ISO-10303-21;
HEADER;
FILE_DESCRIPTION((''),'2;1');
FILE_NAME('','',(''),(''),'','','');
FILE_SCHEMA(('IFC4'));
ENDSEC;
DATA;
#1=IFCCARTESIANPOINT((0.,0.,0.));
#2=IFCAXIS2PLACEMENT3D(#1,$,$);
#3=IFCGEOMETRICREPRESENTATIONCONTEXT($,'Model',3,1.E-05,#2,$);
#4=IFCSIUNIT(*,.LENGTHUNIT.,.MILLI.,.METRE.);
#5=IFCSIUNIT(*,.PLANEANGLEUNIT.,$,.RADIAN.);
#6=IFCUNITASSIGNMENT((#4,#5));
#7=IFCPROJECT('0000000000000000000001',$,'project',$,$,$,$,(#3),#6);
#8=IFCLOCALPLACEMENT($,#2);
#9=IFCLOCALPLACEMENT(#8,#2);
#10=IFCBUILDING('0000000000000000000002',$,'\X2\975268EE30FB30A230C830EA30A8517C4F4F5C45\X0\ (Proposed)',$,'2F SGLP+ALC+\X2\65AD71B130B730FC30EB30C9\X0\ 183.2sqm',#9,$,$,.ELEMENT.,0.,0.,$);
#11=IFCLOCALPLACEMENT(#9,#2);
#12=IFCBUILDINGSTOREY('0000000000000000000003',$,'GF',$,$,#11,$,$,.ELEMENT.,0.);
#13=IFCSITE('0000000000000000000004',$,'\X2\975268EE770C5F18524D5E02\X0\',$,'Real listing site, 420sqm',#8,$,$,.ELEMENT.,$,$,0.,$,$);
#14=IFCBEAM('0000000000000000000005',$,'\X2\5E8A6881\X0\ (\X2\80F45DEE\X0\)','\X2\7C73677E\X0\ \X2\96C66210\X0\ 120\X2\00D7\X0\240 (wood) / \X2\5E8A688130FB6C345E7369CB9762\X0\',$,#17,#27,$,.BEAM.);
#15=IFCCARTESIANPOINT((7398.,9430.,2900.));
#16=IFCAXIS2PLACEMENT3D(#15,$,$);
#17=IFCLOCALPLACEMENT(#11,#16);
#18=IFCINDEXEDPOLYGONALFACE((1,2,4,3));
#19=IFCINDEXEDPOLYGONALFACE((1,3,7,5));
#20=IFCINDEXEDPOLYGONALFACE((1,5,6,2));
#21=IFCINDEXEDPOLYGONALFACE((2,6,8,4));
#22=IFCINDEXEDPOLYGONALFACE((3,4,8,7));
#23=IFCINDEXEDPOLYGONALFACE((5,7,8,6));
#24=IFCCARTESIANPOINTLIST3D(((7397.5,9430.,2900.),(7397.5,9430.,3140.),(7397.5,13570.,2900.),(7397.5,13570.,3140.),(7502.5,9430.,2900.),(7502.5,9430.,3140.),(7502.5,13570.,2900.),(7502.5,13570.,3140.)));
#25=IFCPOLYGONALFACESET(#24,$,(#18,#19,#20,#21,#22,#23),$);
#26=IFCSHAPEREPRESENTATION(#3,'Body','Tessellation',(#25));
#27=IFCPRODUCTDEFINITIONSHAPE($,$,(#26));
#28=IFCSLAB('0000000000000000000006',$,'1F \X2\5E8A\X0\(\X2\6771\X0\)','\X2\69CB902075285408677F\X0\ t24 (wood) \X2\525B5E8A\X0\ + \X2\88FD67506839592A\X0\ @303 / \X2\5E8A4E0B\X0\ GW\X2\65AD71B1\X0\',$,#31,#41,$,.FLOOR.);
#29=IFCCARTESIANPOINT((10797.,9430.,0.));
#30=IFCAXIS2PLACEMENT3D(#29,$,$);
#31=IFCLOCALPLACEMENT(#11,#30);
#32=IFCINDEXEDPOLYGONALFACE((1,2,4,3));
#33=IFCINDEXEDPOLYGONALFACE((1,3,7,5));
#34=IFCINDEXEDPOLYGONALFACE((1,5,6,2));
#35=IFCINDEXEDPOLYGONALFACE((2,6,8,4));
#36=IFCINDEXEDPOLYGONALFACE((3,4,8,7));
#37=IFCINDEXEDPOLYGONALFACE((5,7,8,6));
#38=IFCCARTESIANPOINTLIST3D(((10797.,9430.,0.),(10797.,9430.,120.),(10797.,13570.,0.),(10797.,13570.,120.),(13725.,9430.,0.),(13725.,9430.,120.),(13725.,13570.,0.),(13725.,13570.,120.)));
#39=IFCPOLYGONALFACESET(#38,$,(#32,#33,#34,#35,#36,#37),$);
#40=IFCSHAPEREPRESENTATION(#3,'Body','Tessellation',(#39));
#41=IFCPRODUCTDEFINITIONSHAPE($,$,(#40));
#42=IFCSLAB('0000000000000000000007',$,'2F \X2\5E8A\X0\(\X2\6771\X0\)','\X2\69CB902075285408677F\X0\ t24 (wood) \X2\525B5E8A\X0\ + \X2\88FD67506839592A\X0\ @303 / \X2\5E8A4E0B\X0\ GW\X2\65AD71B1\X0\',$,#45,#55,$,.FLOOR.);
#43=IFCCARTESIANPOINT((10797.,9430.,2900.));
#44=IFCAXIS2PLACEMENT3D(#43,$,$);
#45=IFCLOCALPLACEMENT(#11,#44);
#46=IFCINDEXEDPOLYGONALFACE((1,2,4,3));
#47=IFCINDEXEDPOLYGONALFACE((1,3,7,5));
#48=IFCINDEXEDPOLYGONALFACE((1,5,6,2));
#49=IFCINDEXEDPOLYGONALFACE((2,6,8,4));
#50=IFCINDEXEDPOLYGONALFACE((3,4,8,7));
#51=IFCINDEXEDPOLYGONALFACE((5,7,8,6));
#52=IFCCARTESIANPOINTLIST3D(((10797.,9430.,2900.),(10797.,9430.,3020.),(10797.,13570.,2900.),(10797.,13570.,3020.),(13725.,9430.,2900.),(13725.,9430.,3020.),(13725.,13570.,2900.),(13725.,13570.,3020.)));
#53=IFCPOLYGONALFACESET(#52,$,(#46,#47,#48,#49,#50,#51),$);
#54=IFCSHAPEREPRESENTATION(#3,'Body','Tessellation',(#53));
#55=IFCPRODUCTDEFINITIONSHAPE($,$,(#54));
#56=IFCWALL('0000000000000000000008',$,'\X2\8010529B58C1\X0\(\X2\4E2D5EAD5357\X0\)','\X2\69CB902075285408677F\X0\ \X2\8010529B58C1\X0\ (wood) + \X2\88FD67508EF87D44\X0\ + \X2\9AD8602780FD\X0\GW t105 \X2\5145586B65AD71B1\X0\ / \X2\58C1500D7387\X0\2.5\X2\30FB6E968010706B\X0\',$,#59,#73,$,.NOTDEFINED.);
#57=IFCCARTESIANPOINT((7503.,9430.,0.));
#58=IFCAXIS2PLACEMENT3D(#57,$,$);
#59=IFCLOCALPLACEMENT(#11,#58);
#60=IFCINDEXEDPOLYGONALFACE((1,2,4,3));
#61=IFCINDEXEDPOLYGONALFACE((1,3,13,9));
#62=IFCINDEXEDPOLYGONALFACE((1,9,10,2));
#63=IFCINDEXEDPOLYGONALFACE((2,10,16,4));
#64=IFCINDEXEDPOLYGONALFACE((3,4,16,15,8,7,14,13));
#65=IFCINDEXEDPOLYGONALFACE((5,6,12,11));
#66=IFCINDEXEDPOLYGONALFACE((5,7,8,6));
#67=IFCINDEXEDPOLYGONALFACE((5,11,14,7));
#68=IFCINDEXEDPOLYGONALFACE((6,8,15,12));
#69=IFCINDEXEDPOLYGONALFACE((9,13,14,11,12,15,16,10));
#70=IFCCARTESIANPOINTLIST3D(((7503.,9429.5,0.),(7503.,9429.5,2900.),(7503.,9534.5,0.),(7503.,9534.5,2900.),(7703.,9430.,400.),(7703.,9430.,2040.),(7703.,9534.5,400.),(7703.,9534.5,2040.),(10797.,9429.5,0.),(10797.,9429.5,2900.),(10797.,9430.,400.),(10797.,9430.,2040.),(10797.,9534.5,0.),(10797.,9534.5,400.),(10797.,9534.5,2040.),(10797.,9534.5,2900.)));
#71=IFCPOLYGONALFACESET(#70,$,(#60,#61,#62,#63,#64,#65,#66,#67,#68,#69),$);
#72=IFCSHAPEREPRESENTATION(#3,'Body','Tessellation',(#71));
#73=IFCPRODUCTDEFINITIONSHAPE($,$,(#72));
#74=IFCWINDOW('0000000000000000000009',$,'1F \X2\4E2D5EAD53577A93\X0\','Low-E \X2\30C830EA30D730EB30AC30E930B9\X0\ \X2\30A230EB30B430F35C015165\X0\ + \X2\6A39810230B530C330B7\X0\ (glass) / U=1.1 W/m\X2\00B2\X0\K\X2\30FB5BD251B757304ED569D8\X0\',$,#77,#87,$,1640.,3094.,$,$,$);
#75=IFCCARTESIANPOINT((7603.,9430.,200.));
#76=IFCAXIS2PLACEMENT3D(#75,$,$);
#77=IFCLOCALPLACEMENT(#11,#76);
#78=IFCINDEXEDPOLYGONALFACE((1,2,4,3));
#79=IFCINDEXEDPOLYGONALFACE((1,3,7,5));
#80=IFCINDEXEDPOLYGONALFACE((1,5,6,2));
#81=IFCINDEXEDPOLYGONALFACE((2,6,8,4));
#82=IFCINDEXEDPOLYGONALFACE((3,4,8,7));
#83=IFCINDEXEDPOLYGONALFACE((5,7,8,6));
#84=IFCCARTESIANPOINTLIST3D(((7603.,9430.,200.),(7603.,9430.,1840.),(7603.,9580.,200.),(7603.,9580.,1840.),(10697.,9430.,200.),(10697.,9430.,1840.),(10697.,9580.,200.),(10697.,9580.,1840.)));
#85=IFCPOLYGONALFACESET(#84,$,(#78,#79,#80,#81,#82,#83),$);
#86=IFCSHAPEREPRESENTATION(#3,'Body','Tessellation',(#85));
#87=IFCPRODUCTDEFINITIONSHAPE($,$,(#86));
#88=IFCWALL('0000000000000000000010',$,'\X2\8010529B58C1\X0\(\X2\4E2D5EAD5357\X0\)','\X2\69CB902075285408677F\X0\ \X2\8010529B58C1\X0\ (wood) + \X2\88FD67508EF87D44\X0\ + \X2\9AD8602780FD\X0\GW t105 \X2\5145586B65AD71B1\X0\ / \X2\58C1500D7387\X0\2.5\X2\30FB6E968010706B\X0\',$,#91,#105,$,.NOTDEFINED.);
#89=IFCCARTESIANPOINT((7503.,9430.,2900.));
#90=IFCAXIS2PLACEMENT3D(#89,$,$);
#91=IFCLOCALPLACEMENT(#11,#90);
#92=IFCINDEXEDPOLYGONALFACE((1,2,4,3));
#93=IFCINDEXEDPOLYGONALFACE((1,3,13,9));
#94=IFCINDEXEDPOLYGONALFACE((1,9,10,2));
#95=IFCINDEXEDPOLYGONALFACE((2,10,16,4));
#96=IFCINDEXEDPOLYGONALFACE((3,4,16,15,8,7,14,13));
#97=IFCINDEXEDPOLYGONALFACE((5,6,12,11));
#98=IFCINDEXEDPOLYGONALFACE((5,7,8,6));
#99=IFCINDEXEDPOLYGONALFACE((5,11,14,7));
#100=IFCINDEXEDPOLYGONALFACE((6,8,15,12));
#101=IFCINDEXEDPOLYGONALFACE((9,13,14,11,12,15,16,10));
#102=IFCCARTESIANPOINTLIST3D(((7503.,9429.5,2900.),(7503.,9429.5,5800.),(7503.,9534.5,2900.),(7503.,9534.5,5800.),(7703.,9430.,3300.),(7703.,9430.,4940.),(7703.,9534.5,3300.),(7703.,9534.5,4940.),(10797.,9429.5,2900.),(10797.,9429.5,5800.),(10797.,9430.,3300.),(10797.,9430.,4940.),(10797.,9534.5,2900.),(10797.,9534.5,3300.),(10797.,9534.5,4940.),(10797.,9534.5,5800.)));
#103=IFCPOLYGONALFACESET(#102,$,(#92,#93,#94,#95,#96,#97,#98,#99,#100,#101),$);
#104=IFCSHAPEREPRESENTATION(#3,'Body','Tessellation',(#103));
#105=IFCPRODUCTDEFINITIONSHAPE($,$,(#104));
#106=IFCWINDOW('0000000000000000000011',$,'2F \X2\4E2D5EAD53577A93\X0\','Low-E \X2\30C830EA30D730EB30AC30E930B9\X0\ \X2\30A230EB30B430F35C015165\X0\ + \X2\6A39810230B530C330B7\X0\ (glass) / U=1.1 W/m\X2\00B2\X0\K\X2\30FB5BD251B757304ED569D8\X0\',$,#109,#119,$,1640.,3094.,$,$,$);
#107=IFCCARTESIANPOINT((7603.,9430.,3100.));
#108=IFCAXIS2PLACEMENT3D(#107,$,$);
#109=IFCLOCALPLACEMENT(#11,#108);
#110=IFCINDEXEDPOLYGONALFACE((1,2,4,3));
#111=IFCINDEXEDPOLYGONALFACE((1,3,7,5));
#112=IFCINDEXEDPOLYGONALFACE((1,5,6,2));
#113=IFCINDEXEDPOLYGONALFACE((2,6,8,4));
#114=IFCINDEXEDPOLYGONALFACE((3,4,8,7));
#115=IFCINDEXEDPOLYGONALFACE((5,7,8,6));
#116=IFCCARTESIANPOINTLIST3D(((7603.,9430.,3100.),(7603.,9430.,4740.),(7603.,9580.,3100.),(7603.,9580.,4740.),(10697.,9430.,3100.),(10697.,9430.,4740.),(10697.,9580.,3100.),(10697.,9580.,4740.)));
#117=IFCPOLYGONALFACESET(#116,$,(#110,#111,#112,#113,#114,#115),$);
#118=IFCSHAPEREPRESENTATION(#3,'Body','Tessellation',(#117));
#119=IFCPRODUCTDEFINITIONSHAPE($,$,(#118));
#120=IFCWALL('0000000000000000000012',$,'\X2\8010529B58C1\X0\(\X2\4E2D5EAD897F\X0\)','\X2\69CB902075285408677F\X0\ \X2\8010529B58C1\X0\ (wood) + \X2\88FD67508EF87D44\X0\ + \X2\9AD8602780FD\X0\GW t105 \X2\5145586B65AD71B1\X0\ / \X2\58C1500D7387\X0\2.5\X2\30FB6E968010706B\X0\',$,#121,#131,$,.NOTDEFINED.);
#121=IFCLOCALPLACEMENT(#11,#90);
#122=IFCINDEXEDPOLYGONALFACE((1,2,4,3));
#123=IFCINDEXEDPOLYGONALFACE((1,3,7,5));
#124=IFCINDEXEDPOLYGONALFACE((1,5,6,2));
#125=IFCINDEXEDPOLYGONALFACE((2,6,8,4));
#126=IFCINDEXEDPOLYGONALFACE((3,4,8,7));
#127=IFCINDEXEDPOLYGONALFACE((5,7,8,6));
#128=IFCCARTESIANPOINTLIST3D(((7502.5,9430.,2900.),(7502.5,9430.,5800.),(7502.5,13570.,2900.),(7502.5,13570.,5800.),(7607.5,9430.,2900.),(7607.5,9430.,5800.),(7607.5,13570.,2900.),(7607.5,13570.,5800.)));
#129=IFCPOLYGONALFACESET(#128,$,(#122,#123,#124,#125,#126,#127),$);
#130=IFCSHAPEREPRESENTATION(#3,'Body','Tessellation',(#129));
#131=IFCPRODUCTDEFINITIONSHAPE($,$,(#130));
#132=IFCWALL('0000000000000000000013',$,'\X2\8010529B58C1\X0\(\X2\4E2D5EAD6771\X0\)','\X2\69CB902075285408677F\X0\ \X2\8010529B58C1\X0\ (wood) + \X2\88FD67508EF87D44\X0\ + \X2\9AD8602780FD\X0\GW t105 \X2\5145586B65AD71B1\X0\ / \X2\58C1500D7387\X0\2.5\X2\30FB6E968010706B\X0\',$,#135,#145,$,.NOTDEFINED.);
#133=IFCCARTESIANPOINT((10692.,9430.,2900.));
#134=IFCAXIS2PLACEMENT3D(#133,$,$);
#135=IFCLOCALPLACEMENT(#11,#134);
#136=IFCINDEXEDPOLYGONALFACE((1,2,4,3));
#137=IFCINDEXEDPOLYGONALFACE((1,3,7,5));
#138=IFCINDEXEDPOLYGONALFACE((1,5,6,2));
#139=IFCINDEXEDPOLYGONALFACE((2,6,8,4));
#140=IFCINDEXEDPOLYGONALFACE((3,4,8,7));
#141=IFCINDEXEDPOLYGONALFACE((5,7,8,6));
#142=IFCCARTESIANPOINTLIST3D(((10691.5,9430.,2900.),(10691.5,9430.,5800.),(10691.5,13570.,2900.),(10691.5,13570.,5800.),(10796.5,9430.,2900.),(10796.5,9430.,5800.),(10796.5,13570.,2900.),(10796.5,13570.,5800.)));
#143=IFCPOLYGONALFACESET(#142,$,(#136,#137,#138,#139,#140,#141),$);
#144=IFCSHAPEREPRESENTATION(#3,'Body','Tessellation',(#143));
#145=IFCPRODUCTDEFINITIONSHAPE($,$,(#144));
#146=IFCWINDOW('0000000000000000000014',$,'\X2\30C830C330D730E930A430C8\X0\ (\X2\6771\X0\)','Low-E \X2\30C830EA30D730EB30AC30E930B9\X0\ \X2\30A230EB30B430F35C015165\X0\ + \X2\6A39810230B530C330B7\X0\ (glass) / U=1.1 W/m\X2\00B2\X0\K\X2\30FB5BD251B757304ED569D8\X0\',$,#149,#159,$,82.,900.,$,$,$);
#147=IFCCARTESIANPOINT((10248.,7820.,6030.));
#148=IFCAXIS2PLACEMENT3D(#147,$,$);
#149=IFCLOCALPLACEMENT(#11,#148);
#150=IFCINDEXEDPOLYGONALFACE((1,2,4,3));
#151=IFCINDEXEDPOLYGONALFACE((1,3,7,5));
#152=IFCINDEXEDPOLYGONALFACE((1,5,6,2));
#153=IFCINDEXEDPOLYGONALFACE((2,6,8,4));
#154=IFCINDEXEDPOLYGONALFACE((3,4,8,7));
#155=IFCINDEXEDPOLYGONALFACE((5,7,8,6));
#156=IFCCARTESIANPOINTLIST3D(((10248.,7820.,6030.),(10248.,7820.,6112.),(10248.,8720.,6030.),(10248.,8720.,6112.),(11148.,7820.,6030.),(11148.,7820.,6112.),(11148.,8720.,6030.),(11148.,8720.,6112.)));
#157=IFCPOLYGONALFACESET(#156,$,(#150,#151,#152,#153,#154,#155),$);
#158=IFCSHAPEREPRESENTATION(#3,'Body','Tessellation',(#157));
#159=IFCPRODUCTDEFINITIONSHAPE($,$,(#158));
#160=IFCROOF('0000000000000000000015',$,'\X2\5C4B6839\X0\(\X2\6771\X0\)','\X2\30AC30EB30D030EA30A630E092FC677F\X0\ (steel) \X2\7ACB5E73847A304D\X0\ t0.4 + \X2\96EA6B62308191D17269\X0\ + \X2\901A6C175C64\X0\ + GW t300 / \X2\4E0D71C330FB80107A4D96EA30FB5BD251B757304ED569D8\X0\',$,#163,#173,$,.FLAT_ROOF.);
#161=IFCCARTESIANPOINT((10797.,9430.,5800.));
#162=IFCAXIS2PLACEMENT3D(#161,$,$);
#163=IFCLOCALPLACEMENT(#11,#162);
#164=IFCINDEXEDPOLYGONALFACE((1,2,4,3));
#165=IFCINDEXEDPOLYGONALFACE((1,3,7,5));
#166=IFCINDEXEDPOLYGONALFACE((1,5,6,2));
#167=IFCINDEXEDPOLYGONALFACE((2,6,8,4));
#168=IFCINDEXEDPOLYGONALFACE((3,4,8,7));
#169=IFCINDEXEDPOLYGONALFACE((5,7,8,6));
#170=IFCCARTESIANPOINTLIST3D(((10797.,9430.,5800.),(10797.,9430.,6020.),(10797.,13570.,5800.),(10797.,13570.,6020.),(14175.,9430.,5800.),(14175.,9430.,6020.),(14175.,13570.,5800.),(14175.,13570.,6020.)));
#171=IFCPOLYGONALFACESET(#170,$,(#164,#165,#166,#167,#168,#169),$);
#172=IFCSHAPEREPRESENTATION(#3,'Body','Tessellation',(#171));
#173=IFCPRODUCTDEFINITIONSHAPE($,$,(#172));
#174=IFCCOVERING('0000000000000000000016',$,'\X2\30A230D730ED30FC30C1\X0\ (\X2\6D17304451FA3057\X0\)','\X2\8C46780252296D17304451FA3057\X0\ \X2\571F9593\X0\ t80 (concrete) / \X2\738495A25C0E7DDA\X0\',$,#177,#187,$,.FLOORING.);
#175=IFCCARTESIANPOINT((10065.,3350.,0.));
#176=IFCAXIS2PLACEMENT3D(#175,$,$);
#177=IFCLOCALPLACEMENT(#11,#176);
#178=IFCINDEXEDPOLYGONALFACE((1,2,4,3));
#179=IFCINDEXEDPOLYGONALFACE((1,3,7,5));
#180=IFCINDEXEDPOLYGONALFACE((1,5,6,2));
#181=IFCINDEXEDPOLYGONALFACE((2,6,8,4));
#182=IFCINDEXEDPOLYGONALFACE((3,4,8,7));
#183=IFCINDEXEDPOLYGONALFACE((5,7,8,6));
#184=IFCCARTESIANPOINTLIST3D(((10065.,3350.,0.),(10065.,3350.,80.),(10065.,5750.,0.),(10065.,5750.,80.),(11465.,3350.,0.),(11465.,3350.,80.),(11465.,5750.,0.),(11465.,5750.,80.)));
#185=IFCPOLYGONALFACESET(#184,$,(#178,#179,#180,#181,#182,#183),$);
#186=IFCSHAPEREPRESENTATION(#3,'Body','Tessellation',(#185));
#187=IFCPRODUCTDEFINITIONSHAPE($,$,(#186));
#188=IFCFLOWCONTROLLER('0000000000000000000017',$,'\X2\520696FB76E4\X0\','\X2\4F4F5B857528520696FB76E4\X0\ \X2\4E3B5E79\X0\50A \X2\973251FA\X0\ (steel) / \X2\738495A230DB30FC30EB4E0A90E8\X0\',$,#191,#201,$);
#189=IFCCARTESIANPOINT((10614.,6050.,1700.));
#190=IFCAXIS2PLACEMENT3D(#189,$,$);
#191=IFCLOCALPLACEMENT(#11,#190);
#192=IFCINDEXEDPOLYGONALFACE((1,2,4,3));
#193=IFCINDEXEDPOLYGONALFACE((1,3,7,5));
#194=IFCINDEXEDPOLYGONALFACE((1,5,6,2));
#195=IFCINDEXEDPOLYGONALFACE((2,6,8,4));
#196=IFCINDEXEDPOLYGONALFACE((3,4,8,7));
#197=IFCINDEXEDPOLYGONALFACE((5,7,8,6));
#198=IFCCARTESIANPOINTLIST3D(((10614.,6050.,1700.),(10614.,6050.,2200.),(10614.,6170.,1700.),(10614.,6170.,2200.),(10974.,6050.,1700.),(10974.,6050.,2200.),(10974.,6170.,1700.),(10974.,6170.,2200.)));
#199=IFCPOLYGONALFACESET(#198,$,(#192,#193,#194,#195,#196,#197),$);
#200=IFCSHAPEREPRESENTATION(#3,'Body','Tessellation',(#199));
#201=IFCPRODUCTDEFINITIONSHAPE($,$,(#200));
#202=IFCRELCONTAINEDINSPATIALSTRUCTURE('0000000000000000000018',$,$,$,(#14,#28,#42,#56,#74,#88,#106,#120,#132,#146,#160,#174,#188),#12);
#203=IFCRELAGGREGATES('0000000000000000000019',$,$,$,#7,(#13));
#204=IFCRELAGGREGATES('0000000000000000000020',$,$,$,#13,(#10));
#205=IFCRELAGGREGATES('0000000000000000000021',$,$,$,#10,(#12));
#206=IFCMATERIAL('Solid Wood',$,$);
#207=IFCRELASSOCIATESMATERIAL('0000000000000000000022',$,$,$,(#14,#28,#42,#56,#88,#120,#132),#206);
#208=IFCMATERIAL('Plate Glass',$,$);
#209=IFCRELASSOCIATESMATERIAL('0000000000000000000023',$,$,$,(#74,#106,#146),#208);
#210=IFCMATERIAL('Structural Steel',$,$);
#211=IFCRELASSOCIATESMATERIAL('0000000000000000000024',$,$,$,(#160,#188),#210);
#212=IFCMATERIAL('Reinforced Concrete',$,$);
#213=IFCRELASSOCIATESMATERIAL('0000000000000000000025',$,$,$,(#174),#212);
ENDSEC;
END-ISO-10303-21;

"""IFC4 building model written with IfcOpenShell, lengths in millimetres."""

from ifc_helpers import new_model, si_unit, frame, frame_2d, origin, place, context, project, spatial, rectangle, extrude, material, element, fill, save


model = new_model("IFC4")

# Units and contexts
model_context = context("Model", 3, precision=1e-05, world=origin())
ifc_project = project(units=[si_unit("LENGTHUNIT", "METRE", prefix="MILLI"), si_unit("PLANEANGLEUNIT", "RADIAN")], contexts=[model_context])

# Site, building, storey
site_placement = place(None, origin())
site = spatial("IfcSite", under=ifc_project, at=site_placement, Name="青森県弘前市", ObjectType="Real listing site, 420sqm", CompositionType="ELEMENT", RefElevation=0.0)
building_placement = place(site_placement, origin())
building = spatial("IfcBuilding", under=site, at=building_placement, Name="青森・アトリエ兼住居 (Proposed)", ObjectType="2F SGLP+ALC+断熱シールド 183.2sqm", CompositionType="ELEMENT", ElevationOfRefHeight=0.0, ElevationOfTerrain=0.0)
storey_placement = place(building_placement, origin())
storey = spatial("IfcBuildingStorey", under=building, at=storey_placement, Name="GF", CompositionType="ELEMENT", Elevation=0.0)

# Shared definitions
ifc_material_1 = material(Name="Solid Wood")

# Beam
beam_placement = place(storey_placement, frame((7398.0, 9430.0, 2900.0)))
element("IfcBeam", 1, at=beam_placement, inside=storey, material=ifc_material_1, Name="床梁 (胴差)", Description="米松 集成 120×240 (wood) / 床梁・水平構面", PredefinedType="BEAM", context=model_context, shape_type="SweptSolid", body=[
    extrude(rectangle(XDim=105.0, YDim=4140.0, at=frame_2d((52.0, 2070.0))), frame((7398.0, 9430.0, 2900.0)), (0.0, 0.0, 1.0), 240.0),
])

# Slabs
slab_1_placement = place(storey_placement, frame((10797.0, 9430.0, 0.0)))
element("IfcSlab", 2, at=slab_1_placement, inside=storey, material=ifc_material_1, Name="1F 床(東)", Description="構造用合板 t24 (wood) 剛床 + 製材根太 @303 / 床下 GW断熱", PredefinedType="FLOOR", context=model_context, shape_type="SweptSolid", body=[
    extrude(rectangle(XDim=2928.0, YDim=4140.0, at=frame_2d((1464.0, 2070.0))), frame((10797.0, 9430.0, 0.0)), (0.0, 0.0, 1.0), 120.0),
])
slab_2_placement = place(storey_placement, frame((10797.0, 9430.0, 2900.0)))
element("IfcSlab", 3, at=slab_2_placement, inside=storey, material=ifc_material_1, Name="2F 床(東)", Description="構造用合板 t24 (wood) 剛床 + 製材根太 @303 / 床下 GW断熱", PredefinedType="FLOOR", context=model_context, shape_type="SweptSolid", body=[
    extrude(rectangle(XDim=2928.0, YDim=4140.0, at=frame_2d((1464.0, 2070.0))), frame((10797.0, 9430.0, 2900.0)), (0.0, 0.0, 1.0), 120.0),
])

# Wall, opening, window
wall_1_placement = place(storey_placement, frame((7503.0, 9430.0, 0.0)))
wall_1 = element("IfcWall", 4, at=wall_1_placement, inside=storey, material=ifc_material_1, Name="耐力壁(中庭南)", Description="構造用合板 耐力壁 (wood) + 製材軸組 + 高性能GW t105 充填断熱 / 壁倍率2.5・準耐火", PredefinedType="NOTDEFINED", context=model_context, shape_type="SweptSolid", body=[
    extrude(rectangle(XDim=3294.0, YDim=105.0, at=frame_2d((1647.0, 52.0))), frame((7503.0, 9430.0, 0.0)), (0.0, 0.0, 1.0), 2900.0),
])
opening_1_placement = place(storey_placement, frame((7603.0, 9430.0, 200.0)))
opening_1 = element("IfcOpeningElement", 5, at=opening_1_placement, cuts=wall_1, PredefinedType="NOTDEFINED", context=model_context, shape_type="SweptSolid", body=[
    extrude(rectangle(XDim=3094.0, YDim=150.0, at=frame_2d((1547.0, 75.0))), frame((7603.0, 9430.0, 200.0)), (0.0, 0.0, 1.0), 1640.0),
])
ifc_material_2 = material(Name="Plate Glass")
window_1_placement = place(storey_placement, frame((7603.0, 9430.0, 200.0)))
window_1 = element("IfcWindow", 6, at=window_1_placement, inside=storey, material=ifc_material_2, Name="1F 中庭南窓", Description="Low-E トリプルガラス アルゴン封入 + 樹脂サッシ (glass) / U=1.1 W/m²K・寒冷地仕様", OverallHeight=1640.0, OverallWidth=3094.0, context=model_context, shape_type="SweptSolid", body=[
    extrude(rectangle(XDim=3094.0, YDim=150.0, at=frame_2d((1547.0, 75.0))), frame((7603.0, 9430.0, 200.0)), (0.0, 0.0, 1.0), 1640.0),
])
fill(opening_1, window_1)

# Wall, opening, window
wall_2_placement = place(storey_placement, frame((7503.0, 9430.0, 2900.0)))
wall_2 = element("IfcWall", 7, at=wall_2_placement, inside=storey, material=ifc_material_1, Name="耐力壁(中庭南)", Description="構造用合板 耐力壁 (wood) + 製材軸組 + 高性能GW t105 充填断熱 / 壁倍率2.5・準耐火", PredefinedType="NOTDEFINED", context=model_context, shape_type="SweptSolid", body=[
    extrude(rectangle(XDim=3294.0, YDim=105.0, at=frame_2d((1647.0, 52.0))), frame((7503.0, 9430.0, 2900.0)), (0.0, 0.0, 1.0), 2900.0),
])
opening_2_placement = place(storey_placement, frame((7603.0, 9430.0, 3100.0)))
opening_2 = element("IfcOpeningElement", 8, at=opening_2_placement, cuts=wall_2, PredefinedType="NOTDEFINED", context=model_context, shape_type="SweptSolid", body=[
    extrude(rectangle(XDim=3094.0, YDim=150.0, at=frame_2d((1547.0, 75.0))), frame((7603.0, 9430.0, 3100.0)), (0.0, 0.0, 1.0), 1640.0),
])
window_2_placement = place(storey_placement, frame((7603.0, 9430.0, 3100.0)))
window_2 = element("IfcWindow", 9, at=window_2_placement, inside=storey, material=ifc_material_2, Name="2F 中庭南窓", Description="Low-E トリプルガラス アルゴン封入 + 樹脂サッシ (glass) / U=1.1 W/m²K・寒冷地仕様", OverallHeight=1640.0, OverallWidth=3094.0, context=model_context, shape_type="SweptSolid", body=[
    extrude(rectangle(XDim=3094.0, YDim=150.0, at=frame_2d((1547.0, 75.0))), frame((7603.0, 9430.0, 3100.0)), (0.0, 0.0, 1.0), 1640.0),
])
fill(opening_2, window_2)

# Walls
wall_3_placement = place(storey_placement, frame((7503.0, 9430.0, 2900.0)))
element("IfcWall", 10, at=wall_3_placement, inside=storey, material=ifc_material_1, Name="耐力壁(中庭西)", Description="構造用合板 耐力壁 (wood) + 製材軸組 + 高性能GW t105 充填断熱 / 壁倍率2.5・準耐火", PredefinedType="NOTDEFINED", context=model_context, shape_type="SweptSolid", body=[
    extrude(rectangle(XDim=105.0, YDim=4140.0, at=frame_2d((52.0, 2070.0))), frame((7503.0, 9430.0, 2900.0)), (0.0, 0.0, 1.0), 2900.0),
])
wall_4_placement = place(storey_placement, frame((10692.0, 9430.0, 2900.0)))
element("IfcWall", 11, at=wall_4_placement, inside=storey, material=ifc_material_1, Name="耐力壁(中庭東)", Description="構造用合板 耐力壁 (wood) + 製材軸組 + 高性能GW t105 充填断熱 / 壁倍率2.5・準耐火", PredefinedType="NOTDEFINED", context=model_context, shape_type="SweptSolid", body=[
    extrude(rectangle(XDim=105.0, YDim=4140.0, at=frame_2d((52.0, 2070.0))), frame((10692.0, 9430.0, 2900.0)), (0.0, 0.0, 1.0), 2900.0),
])

# Window
window_3_placement = place(storey_placement, frame((10248.0, 7820.0, 6030.0)))
element("IfcWindow", 12, at=window_3_placement, inside=storey, material=ifc_material_2, Name="トップライト (東)", Description="Low-E トリプルガラス アルゴン封入 + 樹脂サッシ (glass) / U=1.1 W/m²K・寒冷地仕様", OverallHeight=82.0, OverallWidth=900.0, context=model_context, shape_type="SweptSolid", body=[
    extrude(rectangle(XDim=900.0, YDim=900.0, at=frame_2d((450.0, 450.0))), frame((10248.0, 7820.0, 6030.0)), (0.0, 0.0, 1.0), 82.0),
])

# Roof
ifc_material_3 = material(Name="Structural Steel")
roof_placement = place(storey_placement, frame((10797.0, 9430.0, 5800.0)))
element("IfcRoof", 13, at=roof_placement, inside=storey, material=ifc_material_3, Name="屋根(東)", Description="ガルバリウム鋼板 (steel) 立平葺き t0.4 + 雪止め金物 + 通気層 + GW t300 / 不燃・耐積雪・寒冷地仕様", PredefinedType="FLAT_ROOF", context=model_context, shape_type="SweptSolid", body=[
    extrude(rectangle(XDim=3378.0, YDim=4140.0, at=frame_2d((1689.0, 2070.0))), frame((10797.0, 9430.0, 5800.0)), (0.0, 0.0, 1.0), 220.0),
])

# Covering
ifc_material_4 = material(Name="Reinforced Concrete")
covering_placement = place(storey_placement, frame((10065.0, 3350.0, 0.0)))
element("IfcCovering", 14, at=covering_placement, inside=storey, material=ifc_material_4, Name="アプローチ (洗い出し)", Description="豆砂利洗い出し 土間 t80 (concrete) / 玄関導線", PredefinedType="FLOORING", context=model_context, shape_type="SweptSolid", body=[
    extrude(rectangle(XDim=1400.0, YDim=2400.0, at=frame_2d((700.0, 1200.0))), frame((10065.0, 3350.0, 0.0)), (0.0, 0.0, 1.0), 80.0),
])

# Flow controller
flow_controller_placement = place(storey_placement, frame((10614.0, 6050.0, 1700.0)))
element("IfcFlowController", 15, at=flow_controller_placement, inside=storey, material=ifc_material_3, Name="分電盤", Description="住宅用分電盤 主幹50A 露出 (steel) / 玄関ホール上部", context=model_context, shape_type="SweptSolid", body=[
    extrude(rectangle(XDim=360.0, YDim=120.0, at=frame_2d((180.0, 60.0))), frame((10614.0, 6050.0, 1700.0)), (0.0, 0.0, 1.0), 500.0),
])

save(model, "model.ifc")
